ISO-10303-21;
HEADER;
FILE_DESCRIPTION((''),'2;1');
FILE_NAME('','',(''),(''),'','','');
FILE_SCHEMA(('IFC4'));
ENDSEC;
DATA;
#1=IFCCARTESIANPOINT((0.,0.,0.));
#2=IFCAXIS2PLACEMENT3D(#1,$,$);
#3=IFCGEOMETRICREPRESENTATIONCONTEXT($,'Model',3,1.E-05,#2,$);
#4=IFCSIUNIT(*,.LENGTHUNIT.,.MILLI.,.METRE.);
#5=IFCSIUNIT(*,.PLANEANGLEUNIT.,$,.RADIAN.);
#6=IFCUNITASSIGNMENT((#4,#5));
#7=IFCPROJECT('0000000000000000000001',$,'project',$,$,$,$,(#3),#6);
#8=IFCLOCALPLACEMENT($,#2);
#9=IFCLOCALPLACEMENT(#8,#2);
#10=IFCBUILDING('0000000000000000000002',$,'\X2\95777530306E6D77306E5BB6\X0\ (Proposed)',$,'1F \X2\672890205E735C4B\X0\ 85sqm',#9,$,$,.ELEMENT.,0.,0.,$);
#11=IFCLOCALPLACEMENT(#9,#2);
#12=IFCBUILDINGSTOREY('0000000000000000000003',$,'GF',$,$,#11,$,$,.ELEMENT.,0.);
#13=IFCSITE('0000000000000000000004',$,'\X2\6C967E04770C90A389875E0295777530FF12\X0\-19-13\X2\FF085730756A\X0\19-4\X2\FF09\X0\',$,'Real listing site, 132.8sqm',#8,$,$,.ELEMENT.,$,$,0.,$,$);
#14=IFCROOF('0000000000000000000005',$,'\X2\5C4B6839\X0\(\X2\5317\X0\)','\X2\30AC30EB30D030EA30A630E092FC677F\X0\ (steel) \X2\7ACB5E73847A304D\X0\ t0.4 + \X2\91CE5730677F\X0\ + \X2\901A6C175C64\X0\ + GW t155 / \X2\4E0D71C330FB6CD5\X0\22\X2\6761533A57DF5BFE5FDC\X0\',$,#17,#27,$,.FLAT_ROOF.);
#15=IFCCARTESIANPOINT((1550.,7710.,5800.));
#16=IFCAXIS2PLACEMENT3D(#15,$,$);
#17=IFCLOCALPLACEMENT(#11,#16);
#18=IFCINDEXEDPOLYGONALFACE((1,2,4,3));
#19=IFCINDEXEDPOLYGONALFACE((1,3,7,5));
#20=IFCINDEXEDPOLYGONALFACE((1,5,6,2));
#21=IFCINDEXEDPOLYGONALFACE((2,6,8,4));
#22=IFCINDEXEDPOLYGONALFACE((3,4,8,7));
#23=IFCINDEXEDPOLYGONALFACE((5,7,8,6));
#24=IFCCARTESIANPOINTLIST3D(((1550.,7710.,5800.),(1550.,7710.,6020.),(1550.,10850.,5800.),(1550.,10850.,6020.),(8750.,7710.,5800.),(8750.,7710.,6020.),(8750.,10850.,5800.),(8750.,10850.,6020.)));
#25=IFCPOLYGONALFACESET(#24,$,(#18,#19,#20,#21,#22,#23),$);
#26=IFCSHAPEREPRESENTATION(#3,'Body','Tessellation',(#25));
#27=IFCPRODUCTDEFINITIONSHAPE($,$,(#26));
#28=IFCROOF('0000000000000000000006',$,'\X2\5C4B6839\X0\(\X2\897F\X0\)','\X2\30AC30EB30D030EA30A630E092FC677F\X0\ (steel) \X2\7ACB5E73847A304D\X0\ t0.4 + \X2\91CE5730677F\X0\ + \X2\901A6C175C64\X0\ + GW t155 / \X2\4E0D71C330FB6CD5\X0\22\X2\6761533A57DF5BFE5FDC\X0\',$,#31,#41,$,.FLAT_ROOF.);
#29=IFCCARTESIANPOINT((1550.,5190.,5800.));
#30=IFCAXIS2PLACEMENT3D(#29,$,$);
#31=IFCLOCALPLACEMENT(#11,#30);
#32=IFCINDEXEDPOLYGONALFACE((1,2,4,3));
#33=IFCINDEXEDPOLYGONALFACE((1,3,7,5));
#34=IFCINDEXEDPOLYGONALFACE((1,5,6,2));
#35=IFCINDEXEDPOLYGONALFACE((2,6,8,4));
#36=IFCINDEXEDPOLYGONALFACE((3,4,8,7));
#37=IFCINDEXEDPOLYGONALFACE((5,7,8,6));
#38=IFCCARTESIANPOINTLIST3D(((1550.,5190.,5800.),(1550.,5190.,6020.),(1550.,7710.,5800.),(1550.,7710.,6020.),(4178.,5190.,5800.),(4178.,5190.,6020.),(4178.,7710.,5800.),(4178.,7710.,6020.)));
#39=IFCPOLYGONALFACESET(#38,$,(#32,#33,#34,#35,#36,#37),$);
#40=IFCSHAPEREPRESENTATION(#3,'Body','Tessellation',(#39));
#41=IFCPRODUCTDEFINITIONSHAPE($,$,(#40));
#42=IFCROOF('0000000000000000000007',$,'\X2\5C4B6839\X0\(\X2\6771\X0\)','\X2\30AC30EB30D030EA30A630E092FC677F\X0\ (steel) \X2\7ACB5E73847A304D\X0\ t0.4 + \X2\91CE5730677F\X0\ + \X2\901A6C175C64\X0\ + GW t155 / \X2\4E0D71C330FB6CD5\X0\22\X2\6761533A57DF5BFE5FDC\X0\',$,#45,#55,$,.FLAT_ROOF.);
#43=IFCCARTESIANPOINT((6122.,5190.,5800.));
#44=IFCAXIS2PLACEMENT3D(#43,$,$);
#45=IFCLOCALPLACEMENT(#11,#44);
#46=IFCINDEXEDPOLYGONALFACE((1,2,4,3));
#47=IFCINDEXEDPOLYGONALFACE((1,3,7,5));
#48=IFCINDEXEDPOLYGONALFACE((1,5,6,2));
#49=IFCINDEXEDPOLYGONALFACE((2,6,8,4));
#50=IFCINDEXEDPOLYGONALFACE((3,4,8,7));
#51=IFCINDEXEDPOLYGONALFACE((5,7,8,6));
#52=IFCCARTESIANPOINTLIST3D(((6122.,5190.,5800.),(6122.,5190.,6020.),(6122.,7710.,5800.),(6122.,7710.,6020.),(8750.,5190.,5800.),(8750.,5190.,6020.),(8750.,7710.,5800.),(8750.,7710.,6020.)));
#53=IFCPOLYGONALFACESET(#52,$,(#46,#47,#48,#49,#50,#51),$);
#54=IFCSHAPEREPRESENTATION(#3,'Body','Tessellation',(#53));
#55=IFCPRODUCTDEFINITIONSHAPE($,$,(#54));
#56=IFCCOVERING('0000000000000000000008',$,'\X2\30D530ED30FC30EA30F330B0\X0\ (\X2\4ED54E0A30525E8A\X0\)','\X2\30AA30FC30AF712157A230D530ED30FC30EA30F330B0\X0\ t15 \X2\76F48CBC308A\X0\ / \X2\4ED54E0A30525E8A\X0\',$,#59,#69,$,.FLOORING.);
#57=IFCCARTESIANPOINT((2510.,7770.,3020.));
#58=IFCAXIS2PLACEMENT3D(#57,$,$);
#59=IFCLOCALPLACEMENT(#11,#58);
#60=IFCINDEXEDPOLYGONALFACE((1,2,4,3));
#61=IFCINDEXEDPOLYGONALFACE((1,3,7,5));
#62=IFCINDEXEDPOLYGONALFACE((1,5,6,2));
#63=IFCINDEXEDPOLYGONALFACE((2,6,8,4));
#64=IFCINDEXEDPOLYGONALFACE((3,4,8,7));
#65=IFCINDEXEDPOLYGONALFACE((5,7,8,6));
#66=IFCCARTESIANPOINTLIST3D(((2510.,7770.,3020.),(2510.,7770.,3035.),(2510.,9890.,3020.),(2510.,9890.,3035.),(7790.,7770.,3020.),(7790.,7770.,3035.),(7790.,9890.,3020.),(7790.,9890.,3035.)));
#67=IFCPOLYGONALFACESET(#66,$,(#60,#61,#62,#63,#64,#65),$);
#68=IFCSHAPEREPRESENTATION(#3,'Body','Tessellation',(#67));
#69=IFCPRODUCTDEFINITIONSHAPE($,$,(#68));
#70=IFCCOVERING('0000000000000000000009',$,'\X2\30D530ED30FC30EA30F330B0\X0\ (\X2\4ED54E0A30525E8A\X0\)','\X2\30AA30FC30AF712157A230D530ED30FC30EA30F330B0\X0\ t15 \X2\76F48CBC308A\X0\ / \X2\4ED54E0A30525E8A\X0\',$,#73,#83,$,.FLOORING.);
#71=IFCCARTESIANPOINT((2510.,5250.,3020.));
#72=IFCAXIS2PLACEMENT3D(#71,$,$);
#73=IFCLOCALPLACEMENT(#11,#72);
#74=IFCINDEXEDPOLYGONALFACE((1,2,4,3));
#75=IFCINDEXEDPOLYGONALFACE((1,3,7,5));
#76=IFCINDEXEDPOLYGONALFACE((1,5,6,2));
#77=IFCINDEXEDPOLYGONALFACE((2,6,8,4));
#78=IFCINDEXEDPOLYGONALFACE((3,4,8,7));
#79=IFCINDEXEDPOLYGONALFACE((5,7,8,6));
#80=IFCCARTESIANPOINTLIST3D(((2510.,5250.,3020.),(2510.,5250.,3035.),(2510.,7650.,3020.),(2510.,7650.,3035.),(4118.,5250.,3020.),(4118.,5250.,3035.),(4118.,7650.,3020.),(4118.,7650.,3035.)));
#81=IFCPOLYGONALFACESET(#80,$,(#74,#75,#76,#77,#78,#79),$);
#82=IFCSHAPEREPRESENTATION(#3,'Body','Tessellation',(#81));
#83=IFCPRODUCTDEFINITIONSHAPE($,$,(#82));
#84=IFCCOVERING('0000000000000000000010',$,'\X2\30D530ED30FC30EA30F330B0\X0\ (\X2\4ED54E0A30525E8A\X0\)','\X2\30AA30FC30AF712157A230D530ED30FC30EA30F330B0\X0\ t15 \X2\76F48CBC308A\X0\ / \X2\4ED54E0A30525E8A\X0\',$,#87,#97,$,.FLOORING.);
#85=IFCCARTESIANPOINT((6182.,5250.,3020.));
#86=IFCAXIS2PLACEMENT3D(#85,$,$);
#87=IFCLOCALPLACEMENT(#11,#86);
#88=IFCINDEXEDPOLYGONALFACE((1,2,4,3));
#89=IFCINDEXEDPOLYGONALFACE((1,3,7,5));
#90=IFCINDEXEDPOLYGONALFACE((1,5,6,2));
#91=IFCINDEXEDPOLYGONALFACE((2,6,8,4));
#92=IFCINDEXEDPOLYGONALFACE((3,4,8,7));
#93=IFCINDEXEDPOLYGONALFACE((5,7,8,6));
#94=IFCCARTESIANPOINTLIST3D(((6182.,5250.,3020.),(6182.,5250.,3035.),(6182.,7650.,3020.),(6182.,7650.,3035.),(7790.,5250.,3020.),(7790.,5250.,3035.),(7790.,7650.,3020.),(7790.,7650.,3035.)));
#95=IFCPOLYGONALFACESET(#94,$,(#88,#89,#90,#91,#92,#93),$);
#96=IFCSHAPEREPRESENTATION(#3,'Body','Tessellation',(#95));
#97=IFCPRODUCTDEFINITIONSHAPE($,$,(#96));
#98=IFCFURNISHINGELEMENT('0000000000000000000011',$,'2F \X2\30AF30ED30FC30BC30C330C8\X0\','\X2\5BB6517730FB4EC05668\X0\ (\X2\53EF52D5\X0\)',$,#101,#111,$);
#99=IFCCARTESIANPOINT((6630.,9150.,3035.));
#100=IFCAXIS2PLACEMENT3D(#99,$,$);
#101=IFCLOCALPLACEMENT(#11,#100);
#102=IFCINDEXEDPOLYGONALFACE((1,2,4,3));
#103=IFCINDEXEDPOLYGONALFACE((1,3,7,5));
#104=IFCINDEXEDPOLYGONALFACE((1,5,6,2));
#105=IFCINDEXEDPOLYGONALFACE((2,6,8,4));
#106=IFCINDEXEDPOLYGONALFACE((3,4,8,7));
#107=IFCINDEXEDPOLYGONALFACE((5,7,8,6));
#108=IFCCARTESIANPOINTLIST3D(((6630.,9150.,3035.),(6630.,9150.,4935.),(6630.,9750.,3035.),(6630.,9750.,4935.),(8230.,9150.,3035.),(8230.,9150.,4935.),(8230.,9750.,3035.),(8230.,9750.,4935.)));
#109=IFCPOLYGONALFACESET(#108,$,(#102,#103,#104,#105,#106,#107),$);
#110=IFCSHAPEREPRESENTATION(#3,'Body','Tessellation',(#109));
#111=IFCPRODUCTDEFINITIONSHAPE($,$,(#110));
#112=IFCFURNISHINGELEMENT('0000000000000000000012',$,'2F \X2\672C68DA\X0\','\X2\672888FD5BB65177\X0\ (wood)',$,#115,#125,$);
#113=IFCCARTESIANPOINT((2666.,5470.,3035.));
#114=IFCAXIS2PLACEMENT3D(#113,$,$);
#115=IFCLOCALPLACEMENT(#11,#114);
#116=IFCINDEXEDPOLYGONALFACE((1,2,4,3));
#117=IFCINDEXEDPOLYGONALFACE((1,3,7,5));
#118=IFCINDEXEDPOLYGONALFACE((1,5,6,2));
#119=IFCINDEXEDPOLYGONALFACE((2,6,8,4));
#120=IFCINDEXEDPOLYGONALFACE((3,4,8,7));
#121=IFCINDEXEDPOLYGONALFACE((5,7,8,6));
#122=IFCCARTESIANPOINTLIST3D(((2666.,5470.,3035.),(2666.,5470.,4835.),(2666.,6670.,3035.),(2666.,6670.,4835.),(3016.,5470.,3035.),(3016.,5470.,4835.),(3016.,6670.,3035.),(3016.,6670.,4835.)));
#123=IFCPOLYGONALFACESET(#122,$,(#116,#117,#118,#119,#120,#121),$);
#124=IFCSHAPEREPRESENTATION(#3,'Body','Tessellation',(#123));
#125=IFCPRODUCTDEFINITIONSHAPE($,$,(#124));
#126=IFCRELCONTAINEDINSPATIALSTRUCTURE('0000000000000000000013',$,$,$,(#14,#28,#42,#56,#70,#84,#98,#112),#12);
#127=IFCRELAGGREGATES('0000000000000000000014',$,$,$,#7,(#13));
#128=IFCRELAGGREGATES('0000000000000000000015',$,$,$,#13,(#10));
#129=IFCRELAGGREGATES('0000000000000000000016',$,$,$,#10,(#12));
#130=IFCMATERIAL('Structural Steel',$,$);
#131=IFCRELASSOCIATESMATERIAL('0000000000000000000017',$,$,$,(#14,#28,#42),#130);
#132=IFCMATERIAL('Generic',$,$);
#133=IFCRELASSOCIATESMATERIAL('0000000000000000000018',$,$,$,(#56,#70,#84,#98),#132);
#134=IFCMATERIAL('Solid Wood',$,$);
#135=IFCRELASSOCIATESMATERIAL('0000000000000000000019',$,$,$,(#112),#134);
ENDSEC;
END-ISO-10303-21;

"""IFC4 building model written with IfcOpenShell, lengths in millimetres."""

from ifc_helpers import new_model, si_unit, frame, frame_2d, origin, place, context, project, spatial, rectangle, extrude, material, element, save


model = new_model("IFC4")

# Units and contexts
model_context = context("Model", 3, precision=1e-05, world=origin())
ifc_project = project(units=[si_unit("LENGTHUNIT", "METRE", prefix="MILLI"), si_unit("PLANEANGLEUNIT", "RADIAN")], contexts=[model_context])

# Site, building, storey
site_placement = place(None, origin())
site = spatial("IfcSite", under=ifc_project, at=site_placement, Name="沖縄県那覇市長田２-19-13（地番19-4）", ObjectType="Real listing site, 132.8sqm", CompositionType="ELEMENT", RefElevation=0.0)
building_placement = place(site_placement, origin())
building = spatial("IfcBuilding", under=site, at=building_placement, Name="長田の海の家 (Proposed)", ObjectType="1F 木造平屋 85sqm", CompositionType="ELEMENT", ElevationOfRefHeight=0.0, ElevationOfTerrain=0.0)
storey_placement = place(building_placement, origin())
storey = spatial("IfcBuildingStorey", under=building, at=storey_placement, Name="GF", CompositionType="ELEMENT", Elevation=0.0)

# Shared definitions
ifc_material_1 = material(Name="Solid Wood")

# Roofs
ifc_material_2 = material(Name="Structural Steel")
for number, where, name in (
    (1, (1550.0, 7710.0, 5800.0), "屋根(北)"),
):
    element("IfcRoof", number, at=place(storey_placement, frame(where)), inside=storey, material=ifc_material_2, Name=name, Description="ガルバリウム鋼板 (steel) 立平葺き t0.4 + 野地板 + 通気層 + GW t155 / 不燃・法22条区域対応", PredefinedType="FLAT_ROOF", context=model_context, shape_type="SweptSolid", body=[
        extrude(rectangle(XDim=7200.0, YDim=3140.0, at=frame_2d((3600.0, 1570.0))), frame((1550.0, 7710.0, 5800.0)), (0.0, 0.0, 1.0), 220.0),
    ])
roof_1_placement = place(storey_placement, frame((1550.0, 5190.0, 5800.0)))
element("IfcRoof", 2, at=roof_1_placement, inside=storey, material=ifc_material_2, Name="屋根(西)", Description="ガルバリウム鋼板 (steel) 立平葺き t0.4 + 野地板 + 通気層 + GW t155 / 不燃・法22条区域対応", PredefinedType="FLAT_ROOF", context=model_context, shape_type="SweptSolid", body=[
    extrude(rectangle(XDim=2628.0, YDim=2520.0, at=frame_2d((1314.0, 1260.0))), frame((1550.0, 5190.0, 5800.0)), (0.0, 0.0, 1.0), 220.0),
])
roof_2_placement = place(storey_placement, frame((6122.0, 5190.0, 5800.0)))
element("IfcRoof", 3, at=roof_2_placement, inside=storey, material=ifc_material_2, Name="屋根(東)", Description="ガルバリウム鋼板 (steel) 立平葺き t0.4 + 野地板 + 通気層 + GW t155 / 不燃・法22条区域対応", PredefinedType="FLAT_ROOF", context=model_context, shape_type="SweptSolid", body=[
    extrude(rectangle(XDim=2628.0, YDim=2520.0, at=frame_2d((1314.0, 1260.0))), frame((6122.0, 5190.0, 5800.0)), (0.0, 0.0, 1.0), 220.0),
])

# Coverings
ifc_material_3 = material(Name="Generic")
covering_1_placement = place(storey_placement, frame((2510.0, 7770.0, 3020.0)))
element("IfcCovering", 4, at=covering_1_placement, inside=storey, material=ifc_material_3, Name="フローリング (仕上げ床)", Description="オーク無垢フローリング t15 直貼り / 仕上げ床", PredefinedType="FLOORING", context=model_context, shape_type="SweptSolid", body=[
    extrude(rectangle(XDim=5280.0, YDim=2120.0, at=frame_2d((2640.0, 1060.0))), frame((2510.0, 7770.0, 3020.0)), (0.0, 0.0, 1.0), 15.0),
])
covering_2_placement = place(storey_placement, frame((2510.0, 5250.0, 3020.0)))
element("IfcCovering", 5, at=covering_2_placement, inside=storey, material=ifc_material_3, Name="フローリング (仕上げ床)", Description="オーク無垢フローリング t15 直貼り / 仕上げ床", PredefinedType="FLOORING", context=model_context, shape_type="SweptSolid", body=[
    extrude(rectangle(XDim=1608.0, YDim=2400.0, at=frame_2d((804.0, 1200.0))), frame((2510.0, 5250.0, 3020.0)), (0.0, 0.0, 1.0), 15.0),
])
covering_3_placement = place(storey_placement, frame((6182.0, 5250.0, 3020.0)))
element("IfcCovering", 6, at=covering_3_placement, inside=storey, material=ifc_material_3, Name="フローリング (仕上げ床)", Description="オーク無垢フローリング t15 直貼り / 仕上げ床", PredefinedType="FLOORING", context=model_context, shape_type="SweptSolid", body=[
    extrude(rectangle(XDim=1608.0, YDim=2400.0, at=frame_2d((804.0, 1200.0))), frame((6182.0, 5250.0, 3020.0)), (0.0, 0.0, 1.0), 15.0),
])

# Furnishing elements
furnishing_1_placement = place(storey_placement, frame((6630.0, 9150.0, 3035.0)))
element("IfcFurnishingElement", 7, at=furnishing_1_placement, inside=storey, material=ifc_material_3, Name="2F クローゼット", Description="家具・什器 (可動)", context=model_context, shape_type="SweptSolid", body=[
    extrude(rectangle(XDim=1600.0, YDim=600.0, at=frame_2d((800.0, 300.0))), frame((6630.0, 9150.0, 3035.0)), (0.0, 0.0, 1.0), 1900.0),
])
furnishing_2_placement = place(storey_placement, frame((2666.0, 5470.0, 3035.0)))
element("IfcFurnishingElement", 8, at=furnishing_2_placement, inside=storey, material=ifc_material_1, Name="2F 本棚", Description="木製家具 (wood)", context=model_context, shape_type="SweptSolid", body=[
    extrude(rectangle(XDim=350.0, YDim=1200.0, at=frame_2d((175.0, 600.0))), frame((2666.0, 5470.0, 3035.0)), (0.0, 0.0, 1.0), 1800.0),
])

save(model, "model.ifc")
